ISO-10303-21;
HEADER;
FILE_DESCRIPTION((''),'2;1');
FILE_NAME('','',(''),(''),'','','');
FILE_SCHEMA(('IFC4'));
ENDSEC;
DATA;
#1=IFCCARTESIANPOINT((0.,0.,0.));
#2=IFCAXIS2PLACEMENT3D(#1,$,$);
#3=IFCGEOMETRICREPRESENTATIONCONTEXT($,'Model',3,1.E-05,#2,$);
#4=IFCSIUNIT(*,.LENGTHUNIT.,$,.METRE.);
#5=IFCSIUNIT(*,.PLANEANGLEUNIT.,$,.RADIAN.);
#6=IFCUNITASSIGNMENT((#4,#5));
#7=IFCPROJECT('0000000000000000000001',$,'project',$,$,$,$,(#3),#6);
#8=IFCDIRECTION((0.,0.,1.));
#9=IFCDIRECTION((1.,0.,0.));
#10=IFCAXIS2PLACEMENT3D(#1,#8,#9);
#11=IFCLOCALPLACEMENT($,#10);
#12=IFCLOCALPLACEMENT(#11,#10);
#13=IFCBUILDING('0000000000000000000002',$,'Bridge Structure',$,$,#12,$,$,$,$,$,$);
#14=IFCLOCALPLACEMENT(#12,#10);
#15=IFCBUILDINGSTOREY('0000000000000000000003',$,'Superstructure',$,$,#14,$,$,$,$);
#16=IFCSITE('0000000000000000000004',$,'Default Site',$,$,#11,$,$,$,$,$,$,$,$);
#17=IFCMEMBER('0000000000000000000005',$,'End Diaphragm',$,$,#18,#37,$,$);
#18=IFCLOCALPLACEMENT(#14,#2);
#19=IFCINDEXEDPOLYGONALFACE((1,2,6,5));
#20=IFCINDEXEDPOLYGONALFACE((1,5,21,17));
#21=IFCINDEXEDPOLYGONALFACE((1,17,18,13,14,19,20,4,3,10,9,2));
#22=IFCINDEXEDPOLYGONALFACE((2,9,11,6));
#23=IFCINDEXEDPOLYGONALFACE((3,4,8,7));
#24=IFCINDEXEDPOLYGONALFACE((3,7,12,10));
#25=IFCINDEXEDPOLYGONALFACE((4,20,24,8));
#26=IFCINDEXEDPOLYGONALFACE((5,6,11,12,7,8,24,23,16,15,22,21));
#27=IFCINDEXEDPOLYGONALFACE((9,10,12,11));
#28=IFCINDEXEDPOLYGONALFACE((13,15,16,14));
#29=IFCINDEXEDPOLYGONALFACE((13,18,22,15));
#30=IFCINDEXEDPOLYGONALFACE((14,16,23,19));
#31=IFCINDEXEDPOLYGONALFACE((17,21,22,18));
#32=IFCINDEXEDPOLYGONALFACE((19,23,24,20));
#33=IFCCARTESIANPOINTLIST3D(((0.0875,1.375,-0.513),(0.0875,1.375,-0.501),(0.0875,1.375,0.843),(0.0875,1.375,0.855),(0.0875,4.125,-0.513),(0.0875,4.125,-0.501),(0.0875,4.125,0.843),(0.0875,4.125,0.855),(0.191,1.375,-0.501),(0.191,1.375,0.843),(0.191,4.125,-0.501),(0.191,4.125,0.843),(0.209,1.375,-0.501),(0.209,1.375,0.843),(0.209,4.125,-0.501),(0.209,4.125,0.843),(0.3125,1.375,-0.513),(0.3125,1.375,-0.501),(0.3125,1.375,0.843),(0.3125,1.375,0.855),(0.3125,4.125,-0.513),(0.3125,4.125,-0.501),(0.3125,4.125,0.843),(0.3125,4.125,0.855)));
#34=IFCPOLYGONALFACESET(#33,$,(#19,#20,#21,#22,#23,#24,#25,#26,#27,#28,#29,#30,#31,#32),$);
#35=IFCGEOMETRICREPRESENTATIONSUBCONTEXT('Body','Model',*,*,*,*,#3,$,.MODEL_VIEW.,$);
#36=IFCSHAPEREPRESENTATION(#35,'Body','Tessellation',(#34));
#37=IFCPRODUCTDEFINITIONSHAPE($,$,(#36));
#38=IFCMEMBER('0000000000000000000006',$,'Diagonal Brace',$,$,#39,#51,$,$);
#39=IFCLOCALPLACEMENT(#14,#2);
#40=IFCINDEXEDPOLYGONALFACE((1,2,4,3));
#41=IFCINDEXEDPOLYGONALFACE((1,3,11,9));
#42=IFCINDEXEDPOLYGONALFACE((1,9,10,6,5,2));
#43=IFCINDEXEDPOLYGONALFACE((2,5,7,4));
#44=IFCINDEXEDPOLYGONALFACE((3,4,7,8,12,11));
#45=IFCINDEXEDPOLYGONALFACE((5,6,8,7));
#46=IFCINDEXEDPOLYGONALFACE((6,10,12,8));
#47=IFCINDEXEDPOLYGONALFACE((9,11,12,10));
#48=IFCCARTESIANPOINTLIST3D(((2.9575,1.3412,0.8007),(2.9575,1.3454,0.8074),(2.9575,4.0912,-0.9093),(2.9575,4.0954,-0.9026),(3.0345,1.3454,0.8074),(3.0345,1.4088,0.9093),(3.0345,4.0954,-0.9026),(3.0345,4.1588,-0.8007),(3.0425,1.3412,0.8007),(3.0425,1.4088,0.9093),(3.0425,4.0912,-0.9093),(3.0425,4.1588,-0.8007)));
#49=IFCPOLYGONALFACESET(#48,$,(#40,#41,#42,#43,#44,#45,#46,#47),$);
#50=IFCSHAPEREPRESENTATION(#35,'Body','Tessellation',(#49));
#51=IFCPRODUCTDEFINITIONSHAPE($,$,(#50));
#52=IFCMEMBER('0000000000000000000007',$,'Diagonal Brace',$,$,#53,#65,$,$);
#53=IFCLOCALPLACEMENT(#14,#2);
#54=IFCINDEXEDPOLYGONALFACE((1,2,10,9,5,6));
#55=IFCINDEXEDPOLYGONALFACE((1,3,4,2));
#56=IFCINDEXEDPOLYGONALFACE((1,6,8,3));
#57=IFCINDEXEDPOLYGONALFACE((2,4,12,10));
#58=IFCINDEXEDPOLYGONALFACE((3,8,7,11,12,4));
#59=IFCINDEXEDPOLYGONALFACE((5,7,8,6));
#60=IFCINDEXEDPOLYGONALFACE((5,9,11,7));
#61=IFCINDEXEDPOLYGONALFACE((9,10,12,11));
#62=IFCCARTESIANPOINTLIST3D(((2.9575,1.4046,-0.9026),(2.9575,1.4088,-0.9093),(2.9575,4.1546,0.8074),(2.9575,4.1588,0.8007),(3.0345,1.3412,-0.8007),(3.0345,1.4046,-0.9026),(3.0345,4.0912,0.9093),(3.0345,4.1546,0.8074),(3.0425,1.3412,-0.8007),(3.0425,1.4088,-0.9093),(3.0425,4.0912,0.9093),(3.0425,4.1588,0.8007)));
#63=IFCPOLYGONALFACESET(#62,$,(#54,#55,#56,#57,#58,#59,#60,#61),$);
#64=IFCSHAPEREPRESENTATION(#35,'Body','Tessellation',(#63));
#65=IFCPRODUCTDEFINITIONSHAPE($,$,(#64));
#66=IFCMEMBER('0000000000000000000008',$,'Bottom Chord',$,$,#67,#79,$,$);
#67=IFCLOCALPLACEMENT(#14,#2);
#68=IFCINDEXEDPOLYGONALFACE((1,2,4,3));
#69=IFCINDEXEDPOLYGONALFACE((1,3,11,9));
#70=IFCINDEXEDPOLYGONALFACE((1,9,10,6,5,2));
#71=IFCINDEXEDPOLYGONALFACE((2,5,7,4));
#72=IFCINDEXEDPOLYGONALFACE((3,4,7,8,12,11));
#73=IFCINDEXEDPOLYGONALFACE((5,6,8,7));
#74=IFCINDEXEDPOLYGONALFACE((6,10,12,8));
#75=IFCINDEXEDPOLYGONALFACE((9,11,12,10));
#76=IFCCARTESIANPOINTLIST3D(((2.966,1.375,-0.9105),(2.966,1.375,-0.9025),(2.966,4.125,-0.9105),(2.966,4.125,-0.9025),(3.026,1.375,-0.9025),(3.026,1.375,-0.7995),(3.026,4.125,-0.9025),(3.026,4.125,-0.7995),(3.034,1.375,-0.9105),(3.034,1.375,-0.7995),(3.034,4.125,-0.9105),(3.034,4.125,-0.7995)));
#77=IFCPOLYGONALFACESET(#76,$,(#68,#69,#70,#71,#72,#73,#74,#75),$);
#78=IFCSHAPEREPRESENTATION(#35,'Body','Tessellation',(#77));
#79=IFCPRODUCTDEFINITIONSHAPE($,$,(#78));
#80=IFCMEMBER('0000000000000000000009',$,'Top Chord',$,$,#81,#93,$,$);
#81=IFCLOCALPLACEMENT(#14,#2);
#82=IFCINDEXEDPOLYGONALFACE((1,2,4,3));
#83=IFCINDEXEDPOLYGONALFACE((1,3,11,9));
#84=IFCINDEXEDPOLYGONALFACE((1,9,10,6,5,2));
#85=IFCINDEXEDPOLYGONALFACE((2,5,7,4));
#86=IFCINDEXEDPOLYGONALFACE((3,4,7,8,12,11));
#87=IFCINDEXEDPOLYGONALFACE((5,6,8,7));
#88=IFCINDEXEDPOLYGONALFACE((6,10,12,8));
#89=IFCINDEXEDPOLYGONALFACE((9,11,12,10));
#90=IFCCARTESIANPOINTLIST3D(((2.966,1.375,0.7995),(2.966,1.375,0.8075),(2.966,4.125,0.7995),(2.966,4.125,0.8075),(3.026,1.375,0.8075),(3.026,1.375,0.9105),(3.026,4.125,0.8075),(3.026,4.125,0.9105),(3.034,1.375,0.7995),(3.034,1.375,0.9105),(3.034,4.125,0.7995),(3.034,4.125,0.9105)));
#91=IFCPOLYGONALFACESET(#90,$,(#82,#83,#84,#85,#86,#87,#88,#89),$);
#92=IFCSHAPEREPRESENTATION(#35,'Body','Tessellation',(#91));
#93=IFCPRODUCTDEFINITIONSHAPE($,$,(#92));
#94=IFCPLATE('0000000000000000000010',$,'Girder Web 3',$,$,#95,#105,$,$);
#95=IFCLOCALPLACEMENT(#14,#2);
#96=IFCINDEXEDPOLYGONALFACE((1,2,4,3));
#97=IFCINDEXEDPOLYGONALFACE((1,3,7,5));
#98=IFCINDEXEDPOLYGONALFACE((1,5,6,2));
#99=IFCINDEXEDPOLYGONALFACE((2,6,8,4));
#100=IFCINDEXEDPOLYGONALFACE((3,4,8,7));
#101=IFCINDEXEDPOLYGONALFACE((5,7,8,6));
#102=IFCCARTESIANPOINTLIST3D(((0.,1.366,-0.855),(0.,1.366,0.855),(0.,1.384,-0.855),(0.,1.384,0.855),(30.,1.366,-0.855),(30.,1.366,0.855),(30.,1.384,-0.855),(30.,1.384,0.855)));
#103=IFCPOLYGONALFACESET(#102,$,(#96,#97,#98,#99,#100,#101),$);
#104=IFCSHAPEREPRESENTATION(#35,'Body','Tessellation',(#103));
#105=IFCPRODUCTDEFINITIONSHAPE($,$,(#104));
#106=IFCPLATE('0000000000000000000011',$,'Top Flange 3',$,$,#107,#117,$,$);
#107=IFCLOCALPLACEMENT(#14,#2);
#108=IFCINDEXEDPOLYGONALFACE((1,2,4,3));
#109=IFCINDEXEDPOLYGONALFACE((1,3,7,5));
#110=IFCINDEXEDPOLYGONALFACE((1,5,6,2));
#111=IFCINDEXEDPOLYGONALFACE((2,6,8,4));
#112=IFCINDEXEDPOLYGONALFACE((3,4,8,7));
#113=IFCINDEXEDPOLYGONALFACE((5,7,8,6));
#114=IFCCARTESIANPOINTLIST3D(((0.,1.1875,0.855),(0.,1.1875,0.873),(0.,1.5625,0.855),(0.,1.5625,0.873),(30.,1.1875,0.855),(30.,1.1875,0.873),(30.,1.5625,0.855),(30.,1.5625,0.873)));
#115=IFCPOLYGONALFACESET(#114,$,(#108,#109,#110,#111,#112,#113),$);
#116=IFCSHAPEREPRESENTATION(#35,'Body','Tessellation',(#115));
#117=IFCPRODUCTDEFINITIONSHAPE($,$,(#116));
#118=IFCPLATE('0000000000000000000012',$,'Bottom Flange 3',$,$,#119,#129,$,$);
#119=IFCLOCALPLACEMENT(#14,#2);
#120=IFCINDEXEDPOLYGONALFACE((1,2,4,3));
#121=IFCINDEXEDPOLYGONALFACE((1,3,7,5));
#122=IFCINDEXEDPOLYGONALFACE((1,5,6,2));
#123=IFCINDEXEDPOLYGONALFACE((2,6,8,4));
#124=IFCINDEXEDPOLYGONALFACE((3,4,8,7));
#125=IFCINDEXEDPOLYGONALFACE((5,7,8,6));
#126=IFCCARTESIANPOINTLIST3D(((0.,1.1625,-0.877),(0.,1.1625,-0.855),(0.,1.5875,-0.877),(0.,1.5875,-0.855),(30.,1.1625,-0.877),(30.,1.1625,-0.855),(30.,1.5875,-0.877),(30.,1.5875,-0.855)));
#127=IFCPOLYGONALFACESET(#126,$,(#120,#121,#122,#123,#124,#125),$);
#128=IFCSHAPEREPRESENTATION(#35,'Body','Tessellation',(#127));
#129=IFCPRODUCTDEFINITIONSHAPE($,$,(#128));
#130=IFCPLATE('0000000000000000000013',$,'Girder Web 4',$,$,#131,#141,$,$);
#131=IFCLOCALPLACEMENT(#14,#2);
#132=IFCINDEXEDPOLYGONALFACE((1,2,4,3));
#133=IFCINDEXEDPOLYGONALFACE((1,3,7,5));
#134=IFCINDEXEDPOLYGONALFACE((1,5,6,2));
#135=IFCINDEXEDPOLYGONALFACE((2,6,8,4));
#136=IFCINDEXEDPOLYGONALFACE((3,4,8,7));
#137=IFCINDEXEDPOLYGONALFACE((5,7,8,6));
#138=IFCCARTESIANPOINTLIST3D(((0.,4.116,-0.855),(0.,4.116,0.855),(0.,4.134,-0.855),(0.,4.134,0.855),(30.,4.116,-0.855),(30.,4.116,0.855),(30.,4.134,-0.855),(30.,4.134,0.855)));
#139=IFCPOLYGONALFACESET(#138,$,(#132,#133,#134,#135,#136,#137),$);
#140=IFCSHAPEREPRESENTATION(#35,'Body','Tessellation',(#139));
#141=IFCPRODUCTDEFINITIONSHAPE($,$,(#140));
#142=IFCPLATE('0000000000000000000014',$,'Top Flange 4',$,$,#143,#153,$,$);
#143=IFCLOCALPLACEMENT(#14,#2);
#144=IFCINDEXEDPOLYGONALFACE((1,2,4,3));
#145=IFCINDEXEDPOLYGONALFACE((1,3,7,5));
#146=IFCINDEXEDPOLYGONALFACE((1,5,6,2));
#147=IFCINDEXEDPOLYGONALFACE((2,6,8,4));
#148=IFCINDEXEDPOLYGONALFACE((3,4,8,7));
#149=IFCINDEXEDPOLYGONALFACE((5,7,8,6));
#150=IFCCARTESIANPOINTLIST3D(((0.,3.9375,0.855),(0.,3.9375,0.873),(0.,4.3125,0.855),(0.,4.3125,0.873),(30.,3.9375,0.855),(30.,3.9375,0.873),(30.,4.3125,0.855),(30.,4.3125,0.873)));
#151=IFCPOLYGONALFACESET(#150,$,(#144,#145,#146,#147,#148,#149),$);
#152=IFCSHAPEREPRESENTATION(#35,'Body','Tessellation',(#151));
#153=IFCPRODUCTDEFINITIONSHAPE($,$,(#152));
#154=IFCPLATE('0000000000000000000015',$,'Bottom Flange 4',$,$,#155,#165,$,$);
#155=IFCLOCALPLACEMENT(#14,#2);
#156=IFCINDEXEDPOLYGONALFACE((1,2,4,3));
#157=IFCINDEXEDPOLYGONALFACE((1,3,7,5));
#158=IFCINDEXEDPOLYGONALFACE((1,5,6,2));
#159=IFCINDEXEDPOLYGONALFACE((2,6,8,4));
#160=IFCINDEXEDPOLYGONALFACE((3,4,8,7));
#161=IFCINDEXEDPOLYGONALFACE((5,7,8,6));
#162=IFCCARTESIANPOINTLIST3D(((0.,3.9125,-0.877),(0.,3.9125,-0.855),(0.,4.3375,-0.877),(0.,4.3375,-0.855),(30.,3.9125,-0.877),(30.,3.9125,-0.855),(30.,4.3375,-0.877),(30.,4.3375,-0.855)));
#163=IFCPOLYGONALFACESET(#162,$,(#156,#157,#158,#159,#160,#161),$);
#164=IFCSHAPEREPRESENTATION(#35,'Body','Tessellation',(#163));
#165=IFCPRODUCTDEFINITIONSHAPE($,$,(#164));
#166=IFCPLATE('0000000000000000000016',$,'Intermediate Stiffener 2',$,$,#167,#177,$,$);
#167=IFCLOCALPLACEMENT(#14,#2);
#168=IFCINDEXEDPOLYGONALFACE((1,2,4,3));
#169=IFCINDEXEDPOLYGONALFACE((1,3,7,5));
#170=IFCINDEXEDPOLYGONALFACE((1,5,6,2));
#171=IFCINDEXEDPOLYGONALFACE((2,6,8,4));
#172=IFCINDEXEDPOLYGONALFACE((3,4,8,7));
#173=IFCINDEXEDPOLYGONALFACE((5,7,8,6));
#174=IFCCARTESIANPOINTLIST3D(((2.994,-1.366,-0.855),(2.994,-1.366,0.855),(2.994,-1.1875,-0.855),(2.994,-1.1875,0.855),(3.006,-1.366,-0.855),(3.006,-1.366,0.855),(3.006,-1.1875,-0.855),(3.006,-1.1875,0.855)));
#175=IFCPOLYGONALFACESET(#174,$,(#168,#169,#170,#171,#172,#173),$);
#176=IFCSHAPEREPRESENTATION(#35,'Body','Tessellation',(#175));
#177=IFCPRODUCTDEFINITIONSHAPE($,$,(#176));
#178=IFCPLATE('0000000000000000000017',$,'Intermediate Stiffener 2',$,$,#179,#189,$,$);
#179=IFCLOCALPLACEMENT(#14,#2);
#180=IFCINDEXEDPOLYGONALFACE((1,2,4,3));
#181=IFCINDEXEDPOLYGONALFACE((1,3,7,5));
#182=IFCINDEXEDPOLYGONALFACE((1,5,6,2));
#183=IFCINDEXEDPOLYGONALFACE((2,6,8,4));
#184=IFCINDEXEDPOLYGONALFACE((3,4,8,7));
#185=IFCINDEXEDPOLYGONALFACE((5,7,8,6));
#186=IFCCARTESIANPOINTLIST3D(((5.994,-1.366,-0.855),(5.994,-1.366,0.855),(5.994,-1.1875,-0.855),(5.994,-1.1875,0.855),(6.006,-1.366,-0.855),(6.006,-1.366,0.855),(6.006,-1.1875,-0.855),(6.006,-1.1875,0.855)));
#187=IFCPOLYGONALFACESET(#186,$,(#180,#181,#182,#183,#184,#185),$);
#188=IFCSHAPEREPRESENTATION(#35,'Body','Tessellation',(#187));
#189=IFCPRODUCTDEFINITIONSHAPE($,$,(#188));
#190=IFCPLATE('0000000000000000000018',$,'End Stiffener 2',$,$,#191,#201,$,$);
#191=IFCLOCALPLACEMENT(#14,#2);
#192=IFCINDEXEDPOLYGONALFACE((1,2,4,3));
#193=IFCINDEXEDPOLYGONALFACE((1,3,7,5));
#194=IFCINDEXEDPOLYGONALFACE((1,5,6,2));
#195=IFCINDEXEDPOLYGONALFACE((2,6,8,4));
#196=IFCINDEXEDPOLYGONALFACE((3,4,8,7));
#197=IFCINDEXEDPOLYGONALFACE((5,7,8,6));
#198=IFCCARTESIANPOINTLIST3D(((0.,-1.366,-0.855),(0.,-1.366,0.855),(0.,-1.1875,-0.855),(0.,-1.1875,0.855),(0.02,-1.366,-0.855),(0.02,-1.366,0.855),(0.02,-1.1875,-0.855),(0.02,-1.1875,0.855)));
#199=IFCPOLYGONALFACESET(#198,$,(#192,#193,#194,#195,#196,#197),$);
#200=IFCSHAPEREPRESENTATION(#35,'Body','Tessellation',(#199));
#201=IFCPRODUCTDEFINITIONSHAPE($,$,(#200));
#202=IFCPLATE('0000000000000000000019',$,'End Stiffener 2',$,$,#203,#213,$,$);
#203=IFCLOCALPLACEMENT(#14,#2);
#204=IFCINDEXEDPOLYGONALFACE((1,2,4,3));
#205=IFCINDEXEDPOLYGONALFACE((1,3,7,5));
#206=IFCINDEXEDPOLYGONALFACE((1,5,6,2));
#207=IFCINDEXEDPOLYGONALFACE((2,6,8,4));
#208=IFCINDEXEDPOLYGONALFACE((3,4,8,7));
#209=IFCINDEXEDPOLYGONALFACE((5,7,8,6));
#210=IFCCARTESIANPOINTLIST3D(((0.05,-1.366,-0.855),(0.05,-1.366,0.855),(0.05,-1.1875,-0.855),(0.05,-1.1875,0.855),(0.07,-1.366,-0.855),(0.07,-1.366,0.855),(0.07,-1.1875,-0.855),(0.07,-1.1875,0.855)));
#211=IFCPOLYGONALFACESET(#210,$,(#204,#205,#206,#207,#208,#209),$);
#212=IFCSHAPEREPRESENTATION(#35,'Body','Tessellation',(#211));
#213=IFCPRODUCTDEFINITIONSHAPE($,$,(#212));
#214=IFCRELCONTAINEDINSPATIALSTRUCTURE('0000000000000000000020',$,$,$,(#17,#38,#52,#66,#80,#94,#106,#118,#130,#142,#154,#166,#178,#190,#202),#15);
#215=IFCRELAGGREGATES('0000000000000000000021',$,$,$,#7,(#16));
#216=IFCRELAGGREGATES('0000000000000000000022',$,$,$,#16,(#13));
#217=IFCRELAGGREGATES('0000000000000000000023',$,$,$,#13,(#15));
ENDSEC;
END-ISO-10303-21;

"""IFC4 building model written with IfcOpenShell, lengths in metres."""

from ifc_helpers import new_model, si_unit, frame, origin, origin_with_axes, origin_2d_with_axis, place, context, subcontext, project, spatial, rectangle, i_section, l_section, extrude, element, save


model = new_model("IFC4")

# Units and contexts
model_context = context("Model", 3, precision=1e-05, world=origin())
body_context = subcontext(model_context, "Body", "Model", "MODEL_VIEW")
ifc_project = project(units=[si_unit("LENGTHUNIT", "METRE"), si_unit("PLANEANGLEUNIT", "RADIAN")], contexts=[model_context])

# Site, building, storey
site_placement = place(None, origin_with_axes())
site = spatial("IfcSite", under=ifc_project, at=site_placement, Name="Default Site")
building_placement = place(site_placement, origin_with_axes())
building = spatial("IfcBuilding", under=site, at=building_placement, Name="Bridge Structure")
storey_placement = place(building_placement, origin_with_axes())
storey = spatial("IfcBuildingStorey", under=building, at=storey_placement, Name="Superstructure")

# Members
member_placement = place(storey_placement, frame((0.2, 1.375, 0.171), z_axis=(0.0, 1.0, 0.0), x_axis=(-1.0, 0.0, 0.0)))
element("IfcMember", 1, at=member_placement, inside=storey, Name="End Diaphragm", context=body_context, shape_type="SweptSolid", body=[
    extrude(i_section(OverallWidth=0.225, OverallDepth=1.368, WebThickness=0.018, FlangeThickness=0.012, at=origin_2d_with_axis()), origin_with_axes(), (0.0, 0.0, 1.0), 2.75),
])
for number, where, z_axis, x_axis, name in (
    (2, (3.0, 1.375, 0.855), (0.0, 0.84921, -0.528055), (-1.0, 0.0, 0.0), "Diagonal Brace"),
    (3, (3.0, 1.375, -0.855), (0.0, 0.84921, 0.528055), (-1.0, 0.0, 0.0), "Diagonal Brace"),
):
    element("IfcMember", number, at=place(storey_placement, frame(where, z_axis=z_axis, x_axis=x_axis)), inside=storey, Name=name, context=body_context, shape_type="SweptSolid", body=[
        extrude(l_section(Depth=0.128, Width=0.085, Thickness=0.008, at=origin_2d_with_axis()), origin_with_axes(), (0.0, 0.0, 1.0), 3.2383),
    ])
for number, where, z_axis, x_axis, name in (
    (4, (3.0, 1.375, -0.855), (0.0, 1.0, 0.0), (-1.0, 0.0, 0.0), "Bottom Chord"),
    (5, (3.0, 1.375, 0.855), (0.0, 1.0, 0.0), (-1.0, 0.0, 0.0), "Top Chord"),
):
    element("IfcMember", number, at=place(storey_placement, frame(where, z_axis=z_axis, x_axis=x_axis)), inside=storey, Name=name, context=body_context, shape_type="SweptSolid", body=[
        extrude(l_section(Depth=0.111, Width=0.068, Thickness=0.008, at=origin_2d_with_axis()), origin_with_axes(), (0.0, 0.0, 1.0), 2.75),
    ])

# Plates
plate_1_placement = place(storey_placement, frame((0.0, 1.375, 0.0), z_axis=(1.0, 0.0, 0.0), x_axis=(0.0, 1.0, 0.0)))
element("IfcPlate", 6, at=plate_1_placement, inside=storey, Name="Girder Web 3", context=body_context, shape_type="SweptSolid", body=[
    extrude(rectangle(XDim=0.018, YDim=1.71, at=origin_2d_with_axis()), origin_with_axes(), (0.0, 0.0, 1.0), 30.0),
])
plate_2_placement = place(storey_placement, frame((0.0, 1.375, 0.864), z_axis=(1.0, 0.0, 0.0), x_axis=(0.0, 1.0, 0.0)))
element("IfcPlate", 7, at=plate_2_placement, inside=storey, Name="Top Flange 3", context=body_context, shape_type="SweptSolid", body=[
    extrude(rectangle(XDim=0.375, YDim=0.018, at=origin_2d_with_axis()), origin_with_axes(), (0.0, 0.0, 1.0), 30.0),
])
plate_3_placement = place(storey_placement, frame((0.0, 1.375, -0.866), z_axis=(1.0, 0.0, 0.0), x_axis=(0.0, 1.0, 0.0)))
element("IfcPlate", 8, at=plate_3_placement, inside=storey, Name="Bottom Flange 3", context=body_context, shape_type="SweptSolid", body=[
    extrude(rectangle(XDim=0.425, YDim=0.022, at=origin_2d_with_axis()), origin_with_axes(), (0.0, 0.0, 1.0), 30.0),
])
plate_4_placement = place(storey_placement, frame((0.0, 4.125, 0.0), z_axis=(1.0, 0.0, 0.0), x_axis=(0.0, 1.0, 0.0)))
element("IfcPlate", 9, at=plate_4_placement, inside=storey, Name="Girder Web 4", context=body_context, shape_type="SweptSolid", body=[
    extrude(rectangle(XDim=0.018, YDim=1.71, at=origin_2d_with_axis()), origin_with_axes(), (0.0, 0.0, 1.0), 30.0),
])
plate_5_placement = place(storey_placement, frame((0.0, 4.125, 0.864), z_axis=(1.0, 0.0, 0.0), x_axis=(0.0, 1.0, 0.0)))
element("IfcPlate", 10, at=plate_5_placement, inside=storey, Name="Top Flange 4", context=body_context, shape_type="SweptSolid", body=[
    extrude(rectangle(XDim=0.375, YDim=0.018, at=origin_2d_with_axis()), origin_with_axes(), (0.0, 0.0, 1.0), 30.0),
])
plate_6_placement = place(storey_placement, frame((0.0, 4.125, -0.866), z_axis=(1.0, 0.0, 0.0), x_axis=(0.0, 1.0, 0.0)))
element("IfcPlate", 11, at=plate_6_placement, inside=storey, Name="Bottom Flange 4", context=body_context, shape_type="SweptSolid", body=[
    extrude(rectangle(XDim=0.425, YDim=0.022, at=origin_2d_with_axis()), origin_with_axes(), (0.0, 0.0, 1.0), 30.0),
])
for number, where, z_axis, x_axis, name in (
    (12, (3.0, -1.2768, -0.855), (0.0, 0.0, 1.0), (1.0, 0.0, 0.0), "Intermediate Stiffener 2"),
    (13, (6.0, -1.2768, -0.855), (0.0, 0.0, 1.0), (1.0, 0.0, 0.0), "Intermediate Stiffener 2"),
):
    element("IfcPlate", number, at=place(storey_placement, frame(where, z_axis=z_axis, x_axis=x_axis)), inside=storey, Name=name, context=body_context, shape_type="SweptSolid", body=[
        extrude(rectangle(XDim=0.012, YDim=0.1785, at=origin_2d_with_axis()), origin_with_axes(), (0.0, 0.0, 1.0), 1.71),
    ])
for number, where, z_axis, x_axis, name in (
    (14, (0.01, -1.2768, -0.855), (0.0, 0.0, 1.0), (1.0, 0.0, 0.0), "End Stiffener 2"),
    (15, (0.06, -1.2768, -0.855), (0.0, 0.0, 1.0), (1.0, 0.0, 0.0), "End Stiffener 2"),
):
    element("IfcPlate", number, at=place(storey_placement, frame(where, z_axis=z_axis, x_axis=x_axis)), inside=storey, Name=name, context=body_context, shape_type="SweptSolid", body=[
        extrude(rectangle(XDim=0.02, YDim=0.1785, at=origin_2d_with_axis()), origin_with_axes(), (0.0, 0.0, 1.0), 1.71),
    ])

save(model, "model.ifc")
